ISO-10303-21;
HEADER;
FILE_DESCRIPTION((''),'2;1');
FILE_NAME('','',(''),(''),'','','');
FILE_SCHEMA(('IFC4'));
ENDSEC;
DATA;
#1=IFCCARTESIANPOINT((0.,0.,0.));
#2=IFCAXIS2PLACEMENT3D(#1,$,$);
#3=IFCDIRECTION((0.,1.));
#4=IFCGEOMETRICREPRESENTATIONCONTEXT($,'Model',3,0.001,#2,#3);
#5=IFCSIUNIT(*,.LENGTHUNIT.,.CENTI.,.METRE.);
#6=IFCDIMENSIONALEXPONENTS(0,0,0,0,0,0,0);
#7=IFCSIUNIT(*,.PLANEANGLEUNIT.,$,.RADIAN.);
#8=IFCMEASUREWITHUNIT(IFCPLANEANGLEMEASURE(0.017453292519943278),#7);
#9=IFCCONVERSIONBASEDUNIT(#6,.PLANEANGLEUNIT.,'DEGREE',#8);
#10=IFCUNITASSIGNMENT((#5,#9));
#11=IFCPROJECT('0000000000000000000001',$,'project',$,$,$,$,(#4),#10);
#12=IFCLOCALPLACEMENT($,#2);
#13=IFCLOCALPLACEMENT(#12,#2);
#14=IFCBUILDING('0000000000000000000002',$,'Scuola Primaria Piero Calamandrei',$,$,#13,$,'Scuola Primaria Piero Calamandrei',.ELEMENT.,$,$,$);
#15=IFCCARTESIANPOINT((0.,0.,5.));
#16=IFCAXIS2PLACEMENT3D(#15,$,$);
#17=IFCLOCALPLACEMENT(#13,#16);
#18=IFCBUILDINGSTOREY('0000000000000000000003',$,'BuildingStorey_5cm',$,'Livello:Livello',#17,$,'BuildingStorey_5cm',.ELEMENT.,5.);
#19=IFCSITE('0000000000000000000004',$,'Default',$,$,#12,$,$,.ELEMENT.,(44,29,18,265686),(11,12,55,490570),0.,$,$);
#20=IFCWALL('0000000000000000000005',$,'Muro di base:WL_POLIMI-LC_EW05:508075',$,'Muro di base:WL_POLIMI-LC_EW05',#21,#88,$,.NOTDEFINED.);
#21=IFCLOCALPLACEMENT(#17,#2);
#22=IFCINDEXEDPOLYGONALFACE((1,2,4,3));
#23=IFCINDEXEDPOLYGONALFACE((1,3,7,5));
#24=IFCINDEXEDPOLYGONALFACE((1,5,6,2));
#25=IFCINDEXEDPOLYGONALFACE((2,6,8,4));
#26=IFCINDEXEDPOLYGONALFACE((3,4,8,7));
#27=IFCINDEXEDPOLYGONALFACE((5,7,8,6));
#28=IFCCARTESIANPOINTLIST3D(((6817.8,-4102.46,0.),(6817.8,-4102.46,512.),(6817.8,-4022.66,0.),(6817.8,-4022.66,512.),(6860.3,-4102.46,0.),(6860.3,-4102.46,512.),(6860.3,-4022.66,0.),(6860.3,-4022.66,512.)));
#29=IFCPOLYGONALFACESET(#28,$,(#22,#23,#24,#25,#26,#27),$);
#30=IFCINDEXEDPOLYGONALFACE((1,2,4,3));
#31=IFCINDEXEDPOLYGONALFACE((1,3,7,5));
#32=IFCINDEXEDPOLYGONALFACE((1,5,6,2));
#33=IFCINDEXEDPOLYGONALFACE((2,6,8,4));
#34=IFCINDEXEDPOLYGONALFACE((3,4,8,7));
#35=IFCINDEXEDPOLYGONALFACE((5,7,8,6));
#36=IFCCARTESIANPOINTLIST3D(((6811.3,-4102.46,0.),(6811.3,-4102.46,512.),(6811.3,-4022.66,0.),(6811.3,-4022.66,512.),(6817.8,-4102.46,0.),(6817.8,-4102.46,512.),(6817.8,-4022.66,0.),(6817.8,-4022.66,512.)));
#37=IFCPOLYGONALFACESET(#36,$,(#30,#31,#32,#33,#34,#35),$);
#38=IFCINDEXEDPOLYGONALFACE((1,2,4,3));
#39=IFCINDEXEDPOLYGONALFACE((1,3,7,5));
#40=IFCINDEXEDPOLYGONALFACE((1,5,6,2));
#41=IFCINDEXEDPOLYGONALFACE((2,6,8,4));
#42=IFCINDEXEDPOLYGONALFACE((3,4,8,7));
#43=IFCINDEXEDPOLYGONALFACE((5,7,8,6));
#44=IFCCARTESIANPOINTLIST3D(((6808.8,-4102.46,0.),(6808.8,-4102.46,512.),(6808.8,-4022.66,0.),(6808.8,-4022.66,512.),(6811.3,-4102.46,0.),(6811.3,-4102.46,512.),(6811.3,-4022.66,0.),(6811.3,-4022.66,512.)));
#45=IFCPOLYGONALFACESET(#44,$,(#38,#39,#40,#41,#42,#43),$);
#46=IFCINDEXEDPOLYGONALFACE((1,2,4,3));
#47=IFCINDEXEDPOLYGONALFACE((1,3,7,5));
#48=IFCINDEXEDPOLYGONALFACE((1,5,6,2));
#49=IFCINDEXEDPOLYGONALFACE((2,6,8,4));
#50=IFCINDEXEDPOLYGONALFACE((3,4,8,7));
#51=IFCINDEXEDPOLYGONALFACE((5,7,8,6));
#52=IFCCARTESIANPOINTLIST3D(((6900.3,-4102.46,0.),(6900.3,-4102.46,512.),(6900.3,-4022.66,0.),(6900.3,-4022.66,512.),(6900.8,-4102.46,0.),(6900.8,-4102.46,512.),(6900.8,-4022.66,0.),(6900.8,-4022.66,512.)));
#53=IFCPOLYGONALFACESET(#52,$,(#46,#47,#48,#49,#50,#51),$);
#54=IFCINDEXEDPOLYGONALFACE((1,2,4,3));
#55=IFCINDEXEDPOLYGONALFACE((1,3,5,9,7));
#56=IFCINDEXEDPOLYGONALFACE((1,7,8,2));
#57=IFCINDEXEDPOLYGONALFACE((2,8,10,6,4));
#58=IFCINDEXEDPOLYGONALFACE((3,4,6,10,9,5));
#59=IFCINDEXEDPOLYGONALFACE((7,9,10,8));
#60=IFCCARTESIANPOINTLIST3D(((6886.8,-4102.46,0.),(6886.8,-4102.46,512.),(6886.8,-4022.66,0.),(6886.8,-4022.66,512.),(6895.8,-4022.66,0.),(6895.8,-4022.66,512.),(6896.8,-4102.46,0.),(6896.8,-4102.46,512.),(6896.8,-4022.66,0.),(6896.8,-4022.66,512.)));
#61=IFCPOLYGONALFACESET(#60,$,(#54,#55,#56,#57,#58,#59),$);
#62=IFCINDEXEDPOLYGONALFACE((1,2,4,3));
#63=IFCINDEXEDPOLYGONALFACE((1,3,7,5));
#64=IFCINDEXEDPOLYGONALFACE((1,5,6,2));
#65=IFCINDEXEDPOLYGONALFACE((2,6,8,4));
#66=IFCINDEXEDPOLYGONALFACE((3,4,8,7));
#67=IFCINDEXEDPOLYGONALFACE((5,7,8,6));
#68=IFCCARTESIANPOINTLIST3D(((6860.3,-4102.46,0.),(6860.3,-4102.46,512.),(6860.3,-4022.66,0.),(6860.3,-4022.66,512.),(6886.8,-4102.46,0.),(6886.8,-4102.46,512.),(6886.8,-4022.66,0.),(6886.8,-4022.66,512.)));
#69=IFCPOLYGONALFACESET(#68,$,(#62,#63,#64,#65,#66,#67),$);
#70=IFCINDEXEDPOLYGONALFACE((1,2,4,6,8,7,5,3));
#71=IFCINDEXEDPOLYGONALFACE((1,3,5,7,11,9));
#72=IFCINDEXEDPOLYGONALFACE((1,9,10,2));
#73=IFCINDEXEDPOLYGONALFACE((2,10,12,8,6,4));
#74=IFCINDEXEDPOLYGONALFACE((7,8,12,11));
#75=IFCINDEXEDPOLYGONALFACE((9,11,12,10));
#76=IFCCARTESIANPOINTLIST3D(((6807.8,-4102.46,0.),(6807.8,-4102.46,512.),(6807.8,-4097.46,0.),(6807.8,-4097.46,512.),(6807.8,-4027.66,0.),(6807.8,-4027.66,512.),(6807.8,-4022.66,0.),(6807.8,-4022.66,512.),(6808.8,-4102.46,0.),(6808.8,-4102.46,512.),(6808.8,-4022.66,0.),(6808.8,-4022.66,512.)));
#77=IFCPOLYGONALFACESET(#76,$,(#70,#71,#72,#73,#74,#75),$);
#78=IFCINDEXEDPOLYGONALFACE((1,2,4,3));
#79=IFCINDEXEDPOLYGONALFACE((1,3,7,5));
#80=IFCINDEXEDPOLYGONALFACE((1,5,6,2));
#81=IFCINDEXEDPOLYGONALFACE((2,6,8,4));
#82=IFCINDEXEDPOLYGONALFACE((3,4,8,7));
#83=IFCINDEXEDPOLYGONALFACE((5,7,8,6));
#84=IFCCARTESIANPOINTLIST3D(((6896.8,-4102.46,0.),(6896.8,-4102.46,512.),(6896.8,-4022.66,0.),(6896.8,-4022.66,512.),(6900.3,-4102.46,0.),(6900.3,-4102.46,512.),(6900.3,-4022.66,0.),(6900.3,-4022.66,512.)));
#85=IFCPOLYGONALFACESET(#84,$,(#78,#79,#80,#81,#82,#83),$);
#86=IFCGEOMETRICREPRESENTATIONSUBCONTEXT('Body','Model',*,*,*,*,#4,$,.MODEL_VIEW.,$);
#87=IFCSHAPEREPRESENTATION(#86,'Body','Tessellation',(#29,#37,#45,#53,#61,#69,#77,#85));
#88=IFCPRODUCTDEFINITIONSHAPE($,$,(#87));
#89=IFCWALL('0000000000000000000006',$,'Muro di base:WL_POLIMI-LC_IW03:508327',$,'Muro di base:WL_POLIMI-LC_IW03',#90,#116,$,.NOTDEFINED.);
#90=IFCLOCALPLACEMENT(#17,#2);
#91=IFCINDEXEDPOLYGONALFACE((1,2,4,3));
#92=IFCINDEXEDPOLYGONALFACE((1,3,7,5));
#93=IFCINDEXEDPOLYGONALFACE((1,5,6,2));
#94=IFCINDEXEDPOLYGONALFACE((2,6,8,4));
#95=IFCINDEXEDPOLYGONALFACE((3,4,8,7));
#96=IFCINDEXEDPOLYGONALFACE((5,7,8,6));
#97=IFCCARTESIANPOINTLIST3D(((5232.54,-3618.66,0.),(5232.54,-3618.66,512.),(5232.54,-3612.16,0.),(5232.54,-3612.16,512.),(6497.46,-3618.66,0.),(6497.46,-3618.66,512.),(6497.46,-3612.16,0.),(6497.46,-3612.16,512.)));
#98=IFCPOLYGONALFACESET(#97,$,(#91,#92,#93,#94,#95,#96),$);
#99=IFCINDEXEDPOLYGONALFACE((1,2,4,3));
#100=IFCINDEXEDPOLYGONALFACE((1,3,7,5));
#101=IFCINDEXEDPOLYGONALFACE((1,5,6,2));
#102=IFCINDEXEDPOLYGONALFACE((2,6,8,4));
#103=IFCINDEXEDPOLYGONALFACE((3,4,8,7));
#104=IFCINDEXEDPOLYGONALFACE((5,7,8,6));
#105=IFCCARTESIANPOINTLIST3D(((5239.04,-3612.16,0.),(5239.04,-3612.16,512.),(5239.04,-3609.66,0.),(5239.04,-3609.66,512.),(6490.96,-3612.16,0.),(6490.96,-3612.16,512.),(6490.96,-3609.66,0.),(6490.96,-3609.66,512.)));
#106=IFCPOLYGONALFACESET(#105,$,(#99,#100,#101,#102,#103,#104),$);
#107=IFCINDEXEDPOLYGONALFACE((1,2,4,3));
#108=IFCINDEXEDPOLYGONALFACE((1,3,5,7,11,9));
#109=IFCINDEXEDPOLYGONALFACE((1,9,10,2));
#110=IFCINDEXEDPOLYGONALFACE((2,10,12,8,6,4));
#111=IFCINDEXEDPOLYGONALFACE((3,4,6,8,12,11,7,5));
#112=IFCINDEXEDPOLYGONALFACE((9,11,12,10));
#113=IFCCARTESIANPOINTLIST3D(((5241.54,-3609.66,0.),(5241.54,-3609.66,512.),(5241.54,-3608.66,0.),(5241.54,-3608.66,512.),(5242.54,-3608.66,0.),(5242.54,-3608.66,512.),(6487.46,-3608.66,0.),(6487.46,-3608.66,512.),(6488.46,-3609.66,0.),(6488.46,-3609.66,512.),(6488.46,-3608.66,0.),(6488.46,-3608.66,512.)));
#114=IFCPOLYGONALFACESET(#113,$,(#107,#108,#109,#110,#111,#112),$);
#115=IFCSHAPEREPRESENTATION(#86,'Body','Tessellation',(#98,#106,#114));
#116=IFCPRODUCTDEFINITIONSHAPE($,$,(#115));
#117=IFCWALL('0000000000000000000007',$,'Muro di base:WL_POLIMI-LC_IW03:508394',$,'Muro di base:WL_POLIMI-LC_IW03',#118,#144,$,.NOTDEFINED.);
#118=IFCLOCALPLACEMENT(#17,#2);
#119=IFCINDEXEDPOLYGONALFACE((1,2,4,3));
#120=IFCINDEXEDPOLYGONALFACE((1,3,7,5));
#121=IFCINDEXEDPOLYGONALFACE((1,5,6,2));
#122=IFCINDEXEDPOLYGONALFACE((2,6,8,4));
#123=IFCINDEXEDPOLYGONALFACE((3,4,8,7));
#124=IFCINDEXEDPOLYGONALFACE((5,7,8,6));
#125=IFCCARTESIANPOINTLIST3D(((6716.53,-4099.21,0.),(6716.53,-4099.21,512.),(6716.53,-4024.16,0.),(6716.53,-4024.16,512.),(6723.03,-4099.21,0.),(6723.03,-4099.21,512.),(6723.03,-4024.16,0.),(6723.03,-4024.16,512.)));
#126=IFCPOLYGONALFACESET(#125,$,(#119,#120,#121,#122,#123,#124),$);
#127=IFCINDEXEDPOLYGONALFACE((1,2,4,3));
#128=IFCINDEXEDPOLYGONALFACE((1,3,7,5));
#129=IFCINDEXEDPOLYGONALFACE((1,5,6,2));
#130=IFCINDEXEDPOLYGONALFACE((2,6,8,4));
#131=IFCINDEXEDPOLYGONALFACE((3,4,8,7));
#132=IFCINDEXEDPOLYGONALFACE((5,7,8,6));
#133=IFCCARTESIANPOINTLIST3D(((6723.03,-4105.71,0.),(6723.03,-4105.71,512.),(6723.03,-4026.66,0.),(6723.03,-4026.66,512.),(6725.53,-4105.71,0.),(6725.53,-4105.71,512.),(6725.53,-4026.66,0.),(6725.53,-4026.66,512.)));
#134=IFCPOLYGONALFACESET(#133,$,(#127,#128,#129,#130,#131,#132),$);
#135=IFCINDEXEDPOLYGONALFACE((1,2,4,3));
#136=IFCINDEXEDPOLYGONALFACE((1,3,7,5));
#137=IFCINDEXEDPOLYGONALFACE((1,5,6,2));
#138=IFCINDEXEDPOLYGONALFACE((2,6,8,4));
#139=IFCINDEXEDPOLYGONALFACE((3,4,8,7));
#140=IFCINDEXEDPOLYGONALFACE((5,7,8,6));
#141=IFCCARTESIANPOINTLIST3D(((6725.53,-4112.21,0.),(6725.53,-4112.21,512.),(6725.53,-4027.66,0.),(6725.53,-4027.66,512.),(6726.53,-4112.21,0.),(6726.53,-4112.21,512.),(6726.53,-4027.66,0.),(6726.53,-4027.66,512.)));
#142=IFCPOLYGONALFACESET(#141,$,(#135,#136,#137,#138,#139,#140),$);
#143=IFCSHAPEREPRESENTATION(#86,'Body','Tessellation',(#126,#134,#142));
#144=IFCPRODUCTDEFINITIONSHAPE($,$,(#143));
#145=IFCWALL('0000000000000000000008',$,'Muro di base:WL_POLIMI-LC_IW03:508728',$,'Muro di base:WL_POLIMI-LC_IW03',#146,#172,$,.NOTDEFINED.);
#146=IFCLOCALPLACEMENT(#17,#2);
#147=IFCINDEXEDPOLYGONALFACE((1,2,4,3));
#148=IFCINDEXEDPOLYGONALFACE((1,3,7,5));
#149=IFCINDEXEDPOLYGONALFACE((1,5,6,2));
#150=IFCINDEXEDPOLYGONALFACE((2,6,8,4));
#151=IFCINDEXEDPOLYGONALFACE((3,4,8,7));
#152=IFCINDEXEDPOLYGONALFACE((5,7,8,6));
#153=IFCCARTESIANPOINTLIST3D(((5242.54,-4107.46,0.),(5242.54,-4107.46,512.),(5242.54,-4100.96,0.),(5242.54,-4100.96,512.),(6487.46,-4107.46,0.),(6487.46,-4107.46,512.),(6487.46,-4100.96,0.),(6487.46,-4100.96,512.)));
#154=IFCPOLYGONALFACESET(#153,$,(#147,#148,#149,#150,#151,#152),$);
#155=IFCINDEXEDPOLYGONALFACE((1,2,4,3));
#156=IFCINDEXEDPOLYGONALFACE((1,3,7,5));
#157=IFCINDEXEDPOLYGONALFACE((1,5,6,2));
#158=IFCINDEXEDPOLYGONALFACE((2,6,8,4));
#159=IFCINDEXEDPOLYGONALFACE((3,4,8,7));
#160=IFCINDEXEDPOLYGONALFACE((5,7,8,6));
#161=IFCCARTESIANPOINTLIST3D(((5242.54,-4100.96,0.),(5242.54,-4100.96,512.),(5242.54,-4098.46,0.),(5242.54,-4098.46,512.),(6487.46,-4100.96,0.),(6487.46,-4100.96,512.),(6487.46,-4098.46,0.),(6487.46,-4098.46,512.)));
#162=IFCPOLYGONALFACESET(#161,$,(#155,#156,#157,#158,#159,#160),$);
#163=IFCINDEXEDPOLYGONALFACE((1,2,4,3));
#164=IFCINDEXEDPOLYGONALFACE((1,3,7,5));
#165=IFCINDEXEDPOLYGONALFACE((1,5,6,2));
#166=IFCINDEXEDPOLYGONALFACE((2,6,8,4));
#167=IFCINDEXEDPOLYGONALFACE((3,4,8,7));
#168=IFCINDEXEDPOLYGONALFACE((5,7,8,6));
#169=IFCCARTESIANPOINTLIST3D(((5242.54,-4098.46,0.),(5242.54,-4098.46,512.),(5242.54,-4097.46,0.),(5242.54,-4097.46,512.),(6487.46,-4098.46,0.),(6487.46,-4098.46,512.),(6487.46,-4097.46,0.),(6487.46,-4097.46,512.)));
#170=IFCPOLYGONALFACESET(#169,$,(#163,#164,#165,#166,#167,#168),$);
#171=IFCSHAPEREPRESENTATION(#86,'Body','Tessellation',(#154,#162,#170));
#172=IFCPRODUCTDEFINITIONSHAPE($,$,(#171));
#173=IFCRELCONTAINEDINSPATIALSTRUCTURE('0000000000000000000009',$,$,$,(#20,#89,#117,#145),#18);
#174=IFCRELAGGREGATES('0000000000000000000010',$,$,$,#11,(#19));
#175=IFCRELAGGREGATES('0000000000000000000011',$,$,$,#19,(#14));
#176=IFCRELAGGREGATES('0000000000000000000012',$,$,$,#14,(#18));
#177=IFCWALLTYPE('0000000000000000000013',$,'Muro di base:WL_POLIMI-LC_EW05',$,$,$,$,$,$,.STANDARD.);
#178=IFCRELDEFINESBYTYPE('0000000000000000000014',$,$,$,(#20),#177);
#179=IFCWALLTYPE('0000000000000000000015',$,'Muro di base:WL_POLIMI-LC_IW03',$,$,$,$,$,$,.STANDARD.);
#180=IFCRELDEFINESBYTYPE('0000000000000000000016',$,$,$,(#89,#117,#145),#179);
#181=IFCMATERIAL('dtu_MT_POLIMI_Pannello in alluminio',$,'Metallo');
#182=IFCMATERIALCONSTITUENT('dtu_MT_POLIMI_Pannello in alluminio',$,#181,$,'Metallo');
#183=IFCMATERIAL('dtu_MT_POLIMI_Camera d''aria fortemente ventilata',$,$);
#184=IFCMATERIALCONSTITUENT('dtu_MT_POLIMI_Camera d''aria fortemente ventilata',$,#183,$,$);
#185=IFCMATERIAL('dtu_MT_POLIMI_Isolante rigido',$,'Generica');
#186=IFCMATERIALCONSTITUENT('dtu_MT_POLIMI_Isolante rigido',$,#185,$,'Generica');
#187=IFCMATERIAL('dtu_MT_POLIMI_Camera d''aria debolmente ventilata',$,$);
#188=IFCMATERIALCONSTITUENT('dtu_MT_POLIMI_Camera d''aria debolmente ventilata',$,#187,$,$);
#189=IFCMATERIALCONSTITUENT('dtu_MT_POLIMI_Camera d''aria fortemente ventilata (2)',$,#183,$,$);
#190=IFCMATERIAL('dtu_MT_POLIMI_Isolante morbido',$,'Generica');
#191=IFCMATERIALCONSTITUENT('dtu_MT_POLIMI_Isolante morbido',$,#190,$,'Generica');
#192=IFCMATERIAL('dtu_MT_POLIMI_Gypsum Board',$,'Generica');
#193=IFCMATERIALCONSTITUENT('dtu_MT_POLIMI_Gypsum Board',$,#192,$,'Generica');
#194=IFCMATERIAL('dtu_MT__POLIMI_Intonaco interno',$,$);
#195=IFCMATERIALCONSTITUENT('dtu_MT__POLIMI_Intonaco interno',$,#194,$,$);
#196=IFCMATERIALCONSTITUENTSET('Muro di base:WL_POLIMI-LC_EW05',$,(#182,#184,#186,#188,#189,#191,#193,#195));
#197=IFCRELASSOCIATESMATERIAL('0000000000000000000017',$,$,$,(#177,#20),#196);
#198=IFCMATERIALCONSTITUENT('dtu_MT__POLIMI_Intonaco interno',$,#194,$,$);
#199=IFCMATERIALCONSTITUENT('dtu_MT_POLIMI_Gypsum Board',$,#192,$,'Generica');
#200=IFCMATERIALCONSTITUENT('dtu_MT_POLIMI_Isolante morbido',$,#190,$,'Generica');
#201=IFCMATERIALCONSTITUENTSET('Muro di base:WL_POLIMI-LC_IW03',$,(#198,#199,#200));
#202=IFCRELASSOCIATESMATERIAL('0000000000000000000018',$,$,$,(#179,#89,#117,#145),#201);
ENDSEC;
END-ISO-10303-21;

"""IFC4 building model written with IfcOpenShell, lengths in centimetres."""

from ifc_helpers import new_model, entity, si_unit, converted_unit, direction, frame, origin, place, context, subcontext, project, spatial, indexed_curve, outline, extrude, material, constituent, constituent_set, type_object, element, save


model = new_model("IFC4")

# Units and contexts
model_context = context("Model", 3, precision=0.001, world=origin(), true_north=direction((0.0, 1.0)))
body_context = subcontext(model_context, "Body", "Model", "MODEL_VIEW")
ifc_project = project(units=[si_unit("LENGTHUNIT", "METRE", prefix="CENTI"), converted_unit("PLANEANGLEUNIT", "DEGREE", entity("IfcPlaneAngleMeasure", 0.017453292519943278), si_unit("PLANEANGLEUNIT", "RADIAN"), dimensions=[0, 0, 0, 0, 0, 0, 0])], contexts=[model_context])

# Site, building, storey
site_placement = place(None, origin())
site = spatial("IfcSite", under=ifc_project, at=site_placement, Name="Default", CompositionType="ELEMENT", RefLatitude=(44, 29, 18, 265686), RefLongitude=(11, 12, 55, 490570), RefElevation=0.0)
building_placement = place(site_placement, origin())
building = spatial("IfcBuilding", under=site, at=building_placement, Name="Scuola Primaria Piero Calamandrei", LongName="Scuola Primaria Piero Calamandrei", CompositionType="ELEMENT")
storey_placement = place(building_placement, frame((0.0, 0.0, 5.0)))
storey = spatial("IfcBuildingStorey", under=building, at=storey_placement, Name="BuildingStorey_5cm", ObjectType="Livello:Livello", LongName="BuildingStorey_5cm", CompositionType="ELEMENT", Elevation=5.0)

# Wall
ifc_material_1 = material(Name="dtu_MT_POLIMI_Pannello in alluminio", Category="Metallo")
ifc_constituent_1 = constituent(ifc_material_1, Name="dtu_MT_POLIMI_Pannello in alluminio", Category="Metallo")
ifc_material_2 = material(Name="dtu_MT_POLIMI_Camera d'aria fortemente ventilata")
ifc_constituent_2 = constituent(ifc_material_2, Name="dtu_MT_POLIMI_Camera d'aria fortemente ventilata")
ifc_material_3 = material(Name="dtu_MT_POLIMI_Isolante rigido", Category="Generica")
ifc_constituent_3 = constituent(ifc_material_3, Name="dtu_MT_POLIMI_Isolante rigido", Category="Generica")
ifc_material_4 = material(Name="dtu_MT_POLIMI_Camera d'aria debolmente ventilata")
ifc_constituent_4 = constituent(ifc_material_4, Name="dtu_MT_POLIMI_Camera d'aria debolmente ventilata")
ifc_constituent_5 = constituent(ifc_material_2, Name="dtu_MT_POLIMI_Camera d'aria fortemente ventilata (2)")
ifc_material_5 = material(Name="dtu_MT_POLIMI_Isolante morbido", Category="Generica")
ifc_constituent_6 = constituent(ifc_material_5, Name="dtu_MT_POLIMI_Isolante morbido", Category="Generica")
ifc_material_6 = material(Name="dtu_MT_POLIMI_Gypsum Board", Category="Generica")
ifc_constituent_7 = constituent(ifc_material_6, Name="dtu_MT_POLIMI_Gypsum Board", Category="Generica")
ifc_material_7 = material(Name="dtu_MT__POLIMI_Intonaco interno")
ifc_constituent_8 = constituent(ifc_material_7, Name="dtu_MT__POLIMI_Intonaco interno")
ifc_constituent_set_1 = constituent_set(constituents=[ifc_constituent_1, ifc_constituent_2, ifc_constituent_3, ifc_constituent_4, ifc_constituent_5, ifc_constituent_6, ifc_constituent_7, ifc_constituent_8], Name="Muro di base:WL_POLIMI-LC_EW05")
wall_type_1 = type_object("IfcWallType", Name="Muro di base:WL_POLIMI-LC_EW05", PredefinedType="STANDARD", material=ifc_constituent_set_1)
wall_1_placement = place(storey_placement, frame((6854.3, -4022.66, 0.0), z_axis=(0.0, 0.0, 1.0), x_axis=(0.0, -1.0, 0.0)))
element("IfcWall", 1, at=wall_1_placement, inside=storey, type_object=wall_type_1, material=ifc_constituent_set_1, Name="Muro di base:WL_POLIMI-LC_EW05:508075", ObjectType="Muro di base:WL_POLIMI-LC_EW05", PredefinedType="NOTDEFINED", context=body_context, shape_type="SweptSolid", body=[
    extrude(outline(indexed_curve([(-39.9, -21.25), (39.9, -21.25), (39.9, 21.25), (-39.9, 21.25), (-39.9, -21.25)], self_intersect=False)), frame((39.9, -15.25, 0.0)), (0.0, 0.0, 1.0), 512.0),
    extrude(outline(indexed_curve([(-39.9, -3.25), (39.9, -3.25), (39.9, 3.25), (-39.9, 3.25), (-39.9, -3.25)], self_intersect=False)), frame((39.9, -39.75, 0.0)), (0.0, 0.0, 1.0), 512.0),
    extrude(outline(indexed_curve([(-39.9, -1.25), (39.9, -1.25), (39.9, 1.25), (-39.9, 1.25), (-39.9, -1.25)], self_intersect=False)), frame((39.9, -44.25, 0.0)), (0.0, 0.0, 1.0), 512.0),
    extrude(outline(indexed_curve([(-0.25, -39.9), (0.25, -39.9), (0.25, 39.9), (-0.25, 39.9), (-0.25, -39.9)], self_intersect=False)), frame((39.9, 46.25, 0.0), z_axis=(0.0, 0.0, 1.0), x_axis=(0.0, -1.0, 0.0)), (0.0, 0.0, 1.0), 512.0),
    extrude(outline(indexed_curve([(-31.92, -5.8), (47.88, -5.8), (47.88, 4.2), (-31.92, 4.2), (-31.92, 3.2), (-31.92, -5.8)], self_intersect=False)), frame((31.92, 38.3, 0.0)), (0.0, 0.0, 1.0), 512.0),
    extrude(outline(indexed_curve([(-39.9, -13.25), (39.9, -13.25), (39.9, 13.25), (-39.9, 13.25), (-39.9, -13.25)], self_intersect=False)), frame((39.9, 19.25, 0.0)), (0.0, 0.0, 1.0), 512.0),
    extrude(outline(indexed_curve([(-34.9, -0.33), (34.9, -0.33), (39.9, -0.33), (39.9, 0.67), (-39.9, 0.67), (-39.9, -0.33), (-34.9, -0.33)], self_intersect=False)), frame((39.9, -46.17, 0.0)), (0.0, 0.0, 1.0), 512.0),
    extrude(outline(indexed_curve([(-39.9, -1.75), (39.9, -1.75), (39.9, 1.75), (-39.9, 1.75), (-39.9, -1.75)], self_intersect=False)), frame((39.9, 44.25, 0.0)), (0.0, 0.0, 1.0), 512.0),
])

# Walls
ifc_constituent_9 = constituent(ifc_material_7, Name="dtu_MT__POLIMI_Intonaco interno")
ifc_constituent_10 = constituent(ifc_material_6, Name="dtu_MT_POLIMI_Gypsum Board", Category="Generica")
ifc_constituent_11 = constituent(ifc_material_5, Name="dtu_MT_POLIMI_Isolante morbido", Category="Generica")
ifc_constituent_set_2 = constituent_set(constituents=[ifc_constituent_9, ifc_constituent_10, ifc_constituent_11], Name="Muro di base:WL_POLIMI-LC_IW03")
wall_type_2 = type_object("IfcWallType", Name="Muro di base:WL_POLIMI-LC_IW03", PredefinedType="STANDARD", material=ifc_constituent_set_2)
wall_2_placement = place(storey_placement, frame((5232.54, -3613.66, 0.0)))
element("IfcWall", 2, at=wall_2_placement, inside=storey, type_object=wall_type_2, material=ifc_constituent_set_2, Name="Muro di base:WL_POLIMI-LC_IW03:508327", ObjectType="Muro di base:WL_POLIMI-LC_IW03", PredefinedType="NOTDEFINED", context=body_context, shape_type="SweptSolid", body=[
    extrude(outline(indexed_curve([(-3.25, -632.46), (3.25, -632.46), (3.25, 632.46), (-3.25, 632.46), (-3.25, -632.46)], self_intersect=False)), frame((632.46, -1.75, 0.0), z_axis=(0.0, 0.0, 1.0), x_axis=(0.0, 1.0, 0.0)), (0.0, 0.0, 1.0), 512.0),
    extrude(outline(indexed_curve([(-625.96, -1.25), (625.96, -1.25), (625.96, 1.25), (-625.96, 1.25), (-625.96, -1.25)], self_intersect=False)), frame((632.46, 2.75, 0.0)), (0.0, 0.0, 1.0), 512.0),
    extrude(outline(indexed_curve([(-622.46, -0.33), (622.46, -0.33), (623.46, -0.33), (623.46, 0.67), (-623.46, 0.67), (-623.46, -0.33), (-622.46, -0.33)], self_intersect=False)), frame((632.46, 4.67, 0.0), z_axis=(0.0, 0.0, 1.0), x_axis=(-1.0, 0.0, 0.0)), (0.0, 0.0, 1.0), 512.0),
])
wall_3_placement = place(storey_placement, frame((6721.53, -4027.66, 0.0), z_axis=(0.0, 0.0, 1.0), x_axis=(0.0, -1.0, 0.0)))
element("IfcWall", 3, at=wall_3_placement, inside=storey, type_object=wall_type_2, material=ifc_constituent_set_2, Name="Muro di base:WL_POLIMI-LC_IW03:508394", ObjectType="Muro di base:WL_POLIMI-LC_IW03", PredefinedType="NOTDEFINED", context=body_context, shape_type="SweptSolid", body=[
    extrude(outline(indexed_curve([(-3.25, -37.53), (3.25, -37.53), (3.25, 37.53), (-3.25, 37.53), (-3.25, -37.53)], self_intersect=False)), frame((34.03, -1.75, 0.0), z_axis=(0.0, 0.0, 1.0), x_axis=(0.0, 1.0, 0.0)), (0.0, 0.0, 1.0), 512.0),
    extrude(outline(indexed_curve([(-39.53, -1.25), (39.53, -1.25), (39.53, 1.25), (-39.53, 1.25), (-39.53, -1.25)], self_intersect=False)), frame((38.53, 2.75, 0.0)), (0.0, 0.0, 1.0), 512.0),
    extrude(outline(indexed_curve([(-0.5, -42.28), (0.5, -42.28), (0.5, 42.28), (-0.5, 42.28), (-0.5, -42.28)], self_intersect=False)), frame((42.28, 4.5, 0.0), z_axis=(0.0, 0.0, 1.0), x_axis=(0.0, -1.0, 0.0)), (0.0, 0.0, 1.0), 512.0),
])
wall_4_placement = place(storey_placement, frame((5242.54, -4102.46, 0.0)))
element("IfcWall", 4, at=wall_4_placement, inside=storey, type_object=wall_type_2, material=ifc_constituent_set_2, Name="Muro di base:WL_POLIMI-LC_IW03:508728", ObjectType="Muro di base:WL_POLIMI-LC_IW03", PredefinedType="NOTDEFINED", context=body_context, shape_type="SweptSolid", body=[
    extrude(outline(indexed_curve([(-3.25, -622.46), (3.25, -622.46), (3.25, 622.46), (-3.25, 622.46), (-3.25, -622.46)], self_intersect=False)), frame((622.46, -1.75, 0.0), z_axis=(0.0, 0.0, 1.0), x_axis=(0.0, 1.0, 0.0)), (0.0, 0.0, 1.0), 512.0),
    extrude(outline(indexed_curve([(-622.46, -1.25), (622.46, -1.25), (622.46, 1.25), (-622.46, 1.25), (-622.46, -1.25)], self_intersect=False)), frame((622.46, 2.75, 0.0)), (0.0, 0.0, 1.0), 512.0),
    extrude(outline(indexed_curve([(-0.5, -622.46), (0.5, -622.46), (0.5, 622.46), (-0.5, 622.46), (-0.5, -622.46)], self_intersect=False)), frame((622.46, 4.5, 0.0), z_axis=(0.0, 0.0, 1.0), x_axis=(0.0, -1.0, 0.0)), (0.0, 0.0, 1.0), 512.0),
])

save(model, "model.ifc")
